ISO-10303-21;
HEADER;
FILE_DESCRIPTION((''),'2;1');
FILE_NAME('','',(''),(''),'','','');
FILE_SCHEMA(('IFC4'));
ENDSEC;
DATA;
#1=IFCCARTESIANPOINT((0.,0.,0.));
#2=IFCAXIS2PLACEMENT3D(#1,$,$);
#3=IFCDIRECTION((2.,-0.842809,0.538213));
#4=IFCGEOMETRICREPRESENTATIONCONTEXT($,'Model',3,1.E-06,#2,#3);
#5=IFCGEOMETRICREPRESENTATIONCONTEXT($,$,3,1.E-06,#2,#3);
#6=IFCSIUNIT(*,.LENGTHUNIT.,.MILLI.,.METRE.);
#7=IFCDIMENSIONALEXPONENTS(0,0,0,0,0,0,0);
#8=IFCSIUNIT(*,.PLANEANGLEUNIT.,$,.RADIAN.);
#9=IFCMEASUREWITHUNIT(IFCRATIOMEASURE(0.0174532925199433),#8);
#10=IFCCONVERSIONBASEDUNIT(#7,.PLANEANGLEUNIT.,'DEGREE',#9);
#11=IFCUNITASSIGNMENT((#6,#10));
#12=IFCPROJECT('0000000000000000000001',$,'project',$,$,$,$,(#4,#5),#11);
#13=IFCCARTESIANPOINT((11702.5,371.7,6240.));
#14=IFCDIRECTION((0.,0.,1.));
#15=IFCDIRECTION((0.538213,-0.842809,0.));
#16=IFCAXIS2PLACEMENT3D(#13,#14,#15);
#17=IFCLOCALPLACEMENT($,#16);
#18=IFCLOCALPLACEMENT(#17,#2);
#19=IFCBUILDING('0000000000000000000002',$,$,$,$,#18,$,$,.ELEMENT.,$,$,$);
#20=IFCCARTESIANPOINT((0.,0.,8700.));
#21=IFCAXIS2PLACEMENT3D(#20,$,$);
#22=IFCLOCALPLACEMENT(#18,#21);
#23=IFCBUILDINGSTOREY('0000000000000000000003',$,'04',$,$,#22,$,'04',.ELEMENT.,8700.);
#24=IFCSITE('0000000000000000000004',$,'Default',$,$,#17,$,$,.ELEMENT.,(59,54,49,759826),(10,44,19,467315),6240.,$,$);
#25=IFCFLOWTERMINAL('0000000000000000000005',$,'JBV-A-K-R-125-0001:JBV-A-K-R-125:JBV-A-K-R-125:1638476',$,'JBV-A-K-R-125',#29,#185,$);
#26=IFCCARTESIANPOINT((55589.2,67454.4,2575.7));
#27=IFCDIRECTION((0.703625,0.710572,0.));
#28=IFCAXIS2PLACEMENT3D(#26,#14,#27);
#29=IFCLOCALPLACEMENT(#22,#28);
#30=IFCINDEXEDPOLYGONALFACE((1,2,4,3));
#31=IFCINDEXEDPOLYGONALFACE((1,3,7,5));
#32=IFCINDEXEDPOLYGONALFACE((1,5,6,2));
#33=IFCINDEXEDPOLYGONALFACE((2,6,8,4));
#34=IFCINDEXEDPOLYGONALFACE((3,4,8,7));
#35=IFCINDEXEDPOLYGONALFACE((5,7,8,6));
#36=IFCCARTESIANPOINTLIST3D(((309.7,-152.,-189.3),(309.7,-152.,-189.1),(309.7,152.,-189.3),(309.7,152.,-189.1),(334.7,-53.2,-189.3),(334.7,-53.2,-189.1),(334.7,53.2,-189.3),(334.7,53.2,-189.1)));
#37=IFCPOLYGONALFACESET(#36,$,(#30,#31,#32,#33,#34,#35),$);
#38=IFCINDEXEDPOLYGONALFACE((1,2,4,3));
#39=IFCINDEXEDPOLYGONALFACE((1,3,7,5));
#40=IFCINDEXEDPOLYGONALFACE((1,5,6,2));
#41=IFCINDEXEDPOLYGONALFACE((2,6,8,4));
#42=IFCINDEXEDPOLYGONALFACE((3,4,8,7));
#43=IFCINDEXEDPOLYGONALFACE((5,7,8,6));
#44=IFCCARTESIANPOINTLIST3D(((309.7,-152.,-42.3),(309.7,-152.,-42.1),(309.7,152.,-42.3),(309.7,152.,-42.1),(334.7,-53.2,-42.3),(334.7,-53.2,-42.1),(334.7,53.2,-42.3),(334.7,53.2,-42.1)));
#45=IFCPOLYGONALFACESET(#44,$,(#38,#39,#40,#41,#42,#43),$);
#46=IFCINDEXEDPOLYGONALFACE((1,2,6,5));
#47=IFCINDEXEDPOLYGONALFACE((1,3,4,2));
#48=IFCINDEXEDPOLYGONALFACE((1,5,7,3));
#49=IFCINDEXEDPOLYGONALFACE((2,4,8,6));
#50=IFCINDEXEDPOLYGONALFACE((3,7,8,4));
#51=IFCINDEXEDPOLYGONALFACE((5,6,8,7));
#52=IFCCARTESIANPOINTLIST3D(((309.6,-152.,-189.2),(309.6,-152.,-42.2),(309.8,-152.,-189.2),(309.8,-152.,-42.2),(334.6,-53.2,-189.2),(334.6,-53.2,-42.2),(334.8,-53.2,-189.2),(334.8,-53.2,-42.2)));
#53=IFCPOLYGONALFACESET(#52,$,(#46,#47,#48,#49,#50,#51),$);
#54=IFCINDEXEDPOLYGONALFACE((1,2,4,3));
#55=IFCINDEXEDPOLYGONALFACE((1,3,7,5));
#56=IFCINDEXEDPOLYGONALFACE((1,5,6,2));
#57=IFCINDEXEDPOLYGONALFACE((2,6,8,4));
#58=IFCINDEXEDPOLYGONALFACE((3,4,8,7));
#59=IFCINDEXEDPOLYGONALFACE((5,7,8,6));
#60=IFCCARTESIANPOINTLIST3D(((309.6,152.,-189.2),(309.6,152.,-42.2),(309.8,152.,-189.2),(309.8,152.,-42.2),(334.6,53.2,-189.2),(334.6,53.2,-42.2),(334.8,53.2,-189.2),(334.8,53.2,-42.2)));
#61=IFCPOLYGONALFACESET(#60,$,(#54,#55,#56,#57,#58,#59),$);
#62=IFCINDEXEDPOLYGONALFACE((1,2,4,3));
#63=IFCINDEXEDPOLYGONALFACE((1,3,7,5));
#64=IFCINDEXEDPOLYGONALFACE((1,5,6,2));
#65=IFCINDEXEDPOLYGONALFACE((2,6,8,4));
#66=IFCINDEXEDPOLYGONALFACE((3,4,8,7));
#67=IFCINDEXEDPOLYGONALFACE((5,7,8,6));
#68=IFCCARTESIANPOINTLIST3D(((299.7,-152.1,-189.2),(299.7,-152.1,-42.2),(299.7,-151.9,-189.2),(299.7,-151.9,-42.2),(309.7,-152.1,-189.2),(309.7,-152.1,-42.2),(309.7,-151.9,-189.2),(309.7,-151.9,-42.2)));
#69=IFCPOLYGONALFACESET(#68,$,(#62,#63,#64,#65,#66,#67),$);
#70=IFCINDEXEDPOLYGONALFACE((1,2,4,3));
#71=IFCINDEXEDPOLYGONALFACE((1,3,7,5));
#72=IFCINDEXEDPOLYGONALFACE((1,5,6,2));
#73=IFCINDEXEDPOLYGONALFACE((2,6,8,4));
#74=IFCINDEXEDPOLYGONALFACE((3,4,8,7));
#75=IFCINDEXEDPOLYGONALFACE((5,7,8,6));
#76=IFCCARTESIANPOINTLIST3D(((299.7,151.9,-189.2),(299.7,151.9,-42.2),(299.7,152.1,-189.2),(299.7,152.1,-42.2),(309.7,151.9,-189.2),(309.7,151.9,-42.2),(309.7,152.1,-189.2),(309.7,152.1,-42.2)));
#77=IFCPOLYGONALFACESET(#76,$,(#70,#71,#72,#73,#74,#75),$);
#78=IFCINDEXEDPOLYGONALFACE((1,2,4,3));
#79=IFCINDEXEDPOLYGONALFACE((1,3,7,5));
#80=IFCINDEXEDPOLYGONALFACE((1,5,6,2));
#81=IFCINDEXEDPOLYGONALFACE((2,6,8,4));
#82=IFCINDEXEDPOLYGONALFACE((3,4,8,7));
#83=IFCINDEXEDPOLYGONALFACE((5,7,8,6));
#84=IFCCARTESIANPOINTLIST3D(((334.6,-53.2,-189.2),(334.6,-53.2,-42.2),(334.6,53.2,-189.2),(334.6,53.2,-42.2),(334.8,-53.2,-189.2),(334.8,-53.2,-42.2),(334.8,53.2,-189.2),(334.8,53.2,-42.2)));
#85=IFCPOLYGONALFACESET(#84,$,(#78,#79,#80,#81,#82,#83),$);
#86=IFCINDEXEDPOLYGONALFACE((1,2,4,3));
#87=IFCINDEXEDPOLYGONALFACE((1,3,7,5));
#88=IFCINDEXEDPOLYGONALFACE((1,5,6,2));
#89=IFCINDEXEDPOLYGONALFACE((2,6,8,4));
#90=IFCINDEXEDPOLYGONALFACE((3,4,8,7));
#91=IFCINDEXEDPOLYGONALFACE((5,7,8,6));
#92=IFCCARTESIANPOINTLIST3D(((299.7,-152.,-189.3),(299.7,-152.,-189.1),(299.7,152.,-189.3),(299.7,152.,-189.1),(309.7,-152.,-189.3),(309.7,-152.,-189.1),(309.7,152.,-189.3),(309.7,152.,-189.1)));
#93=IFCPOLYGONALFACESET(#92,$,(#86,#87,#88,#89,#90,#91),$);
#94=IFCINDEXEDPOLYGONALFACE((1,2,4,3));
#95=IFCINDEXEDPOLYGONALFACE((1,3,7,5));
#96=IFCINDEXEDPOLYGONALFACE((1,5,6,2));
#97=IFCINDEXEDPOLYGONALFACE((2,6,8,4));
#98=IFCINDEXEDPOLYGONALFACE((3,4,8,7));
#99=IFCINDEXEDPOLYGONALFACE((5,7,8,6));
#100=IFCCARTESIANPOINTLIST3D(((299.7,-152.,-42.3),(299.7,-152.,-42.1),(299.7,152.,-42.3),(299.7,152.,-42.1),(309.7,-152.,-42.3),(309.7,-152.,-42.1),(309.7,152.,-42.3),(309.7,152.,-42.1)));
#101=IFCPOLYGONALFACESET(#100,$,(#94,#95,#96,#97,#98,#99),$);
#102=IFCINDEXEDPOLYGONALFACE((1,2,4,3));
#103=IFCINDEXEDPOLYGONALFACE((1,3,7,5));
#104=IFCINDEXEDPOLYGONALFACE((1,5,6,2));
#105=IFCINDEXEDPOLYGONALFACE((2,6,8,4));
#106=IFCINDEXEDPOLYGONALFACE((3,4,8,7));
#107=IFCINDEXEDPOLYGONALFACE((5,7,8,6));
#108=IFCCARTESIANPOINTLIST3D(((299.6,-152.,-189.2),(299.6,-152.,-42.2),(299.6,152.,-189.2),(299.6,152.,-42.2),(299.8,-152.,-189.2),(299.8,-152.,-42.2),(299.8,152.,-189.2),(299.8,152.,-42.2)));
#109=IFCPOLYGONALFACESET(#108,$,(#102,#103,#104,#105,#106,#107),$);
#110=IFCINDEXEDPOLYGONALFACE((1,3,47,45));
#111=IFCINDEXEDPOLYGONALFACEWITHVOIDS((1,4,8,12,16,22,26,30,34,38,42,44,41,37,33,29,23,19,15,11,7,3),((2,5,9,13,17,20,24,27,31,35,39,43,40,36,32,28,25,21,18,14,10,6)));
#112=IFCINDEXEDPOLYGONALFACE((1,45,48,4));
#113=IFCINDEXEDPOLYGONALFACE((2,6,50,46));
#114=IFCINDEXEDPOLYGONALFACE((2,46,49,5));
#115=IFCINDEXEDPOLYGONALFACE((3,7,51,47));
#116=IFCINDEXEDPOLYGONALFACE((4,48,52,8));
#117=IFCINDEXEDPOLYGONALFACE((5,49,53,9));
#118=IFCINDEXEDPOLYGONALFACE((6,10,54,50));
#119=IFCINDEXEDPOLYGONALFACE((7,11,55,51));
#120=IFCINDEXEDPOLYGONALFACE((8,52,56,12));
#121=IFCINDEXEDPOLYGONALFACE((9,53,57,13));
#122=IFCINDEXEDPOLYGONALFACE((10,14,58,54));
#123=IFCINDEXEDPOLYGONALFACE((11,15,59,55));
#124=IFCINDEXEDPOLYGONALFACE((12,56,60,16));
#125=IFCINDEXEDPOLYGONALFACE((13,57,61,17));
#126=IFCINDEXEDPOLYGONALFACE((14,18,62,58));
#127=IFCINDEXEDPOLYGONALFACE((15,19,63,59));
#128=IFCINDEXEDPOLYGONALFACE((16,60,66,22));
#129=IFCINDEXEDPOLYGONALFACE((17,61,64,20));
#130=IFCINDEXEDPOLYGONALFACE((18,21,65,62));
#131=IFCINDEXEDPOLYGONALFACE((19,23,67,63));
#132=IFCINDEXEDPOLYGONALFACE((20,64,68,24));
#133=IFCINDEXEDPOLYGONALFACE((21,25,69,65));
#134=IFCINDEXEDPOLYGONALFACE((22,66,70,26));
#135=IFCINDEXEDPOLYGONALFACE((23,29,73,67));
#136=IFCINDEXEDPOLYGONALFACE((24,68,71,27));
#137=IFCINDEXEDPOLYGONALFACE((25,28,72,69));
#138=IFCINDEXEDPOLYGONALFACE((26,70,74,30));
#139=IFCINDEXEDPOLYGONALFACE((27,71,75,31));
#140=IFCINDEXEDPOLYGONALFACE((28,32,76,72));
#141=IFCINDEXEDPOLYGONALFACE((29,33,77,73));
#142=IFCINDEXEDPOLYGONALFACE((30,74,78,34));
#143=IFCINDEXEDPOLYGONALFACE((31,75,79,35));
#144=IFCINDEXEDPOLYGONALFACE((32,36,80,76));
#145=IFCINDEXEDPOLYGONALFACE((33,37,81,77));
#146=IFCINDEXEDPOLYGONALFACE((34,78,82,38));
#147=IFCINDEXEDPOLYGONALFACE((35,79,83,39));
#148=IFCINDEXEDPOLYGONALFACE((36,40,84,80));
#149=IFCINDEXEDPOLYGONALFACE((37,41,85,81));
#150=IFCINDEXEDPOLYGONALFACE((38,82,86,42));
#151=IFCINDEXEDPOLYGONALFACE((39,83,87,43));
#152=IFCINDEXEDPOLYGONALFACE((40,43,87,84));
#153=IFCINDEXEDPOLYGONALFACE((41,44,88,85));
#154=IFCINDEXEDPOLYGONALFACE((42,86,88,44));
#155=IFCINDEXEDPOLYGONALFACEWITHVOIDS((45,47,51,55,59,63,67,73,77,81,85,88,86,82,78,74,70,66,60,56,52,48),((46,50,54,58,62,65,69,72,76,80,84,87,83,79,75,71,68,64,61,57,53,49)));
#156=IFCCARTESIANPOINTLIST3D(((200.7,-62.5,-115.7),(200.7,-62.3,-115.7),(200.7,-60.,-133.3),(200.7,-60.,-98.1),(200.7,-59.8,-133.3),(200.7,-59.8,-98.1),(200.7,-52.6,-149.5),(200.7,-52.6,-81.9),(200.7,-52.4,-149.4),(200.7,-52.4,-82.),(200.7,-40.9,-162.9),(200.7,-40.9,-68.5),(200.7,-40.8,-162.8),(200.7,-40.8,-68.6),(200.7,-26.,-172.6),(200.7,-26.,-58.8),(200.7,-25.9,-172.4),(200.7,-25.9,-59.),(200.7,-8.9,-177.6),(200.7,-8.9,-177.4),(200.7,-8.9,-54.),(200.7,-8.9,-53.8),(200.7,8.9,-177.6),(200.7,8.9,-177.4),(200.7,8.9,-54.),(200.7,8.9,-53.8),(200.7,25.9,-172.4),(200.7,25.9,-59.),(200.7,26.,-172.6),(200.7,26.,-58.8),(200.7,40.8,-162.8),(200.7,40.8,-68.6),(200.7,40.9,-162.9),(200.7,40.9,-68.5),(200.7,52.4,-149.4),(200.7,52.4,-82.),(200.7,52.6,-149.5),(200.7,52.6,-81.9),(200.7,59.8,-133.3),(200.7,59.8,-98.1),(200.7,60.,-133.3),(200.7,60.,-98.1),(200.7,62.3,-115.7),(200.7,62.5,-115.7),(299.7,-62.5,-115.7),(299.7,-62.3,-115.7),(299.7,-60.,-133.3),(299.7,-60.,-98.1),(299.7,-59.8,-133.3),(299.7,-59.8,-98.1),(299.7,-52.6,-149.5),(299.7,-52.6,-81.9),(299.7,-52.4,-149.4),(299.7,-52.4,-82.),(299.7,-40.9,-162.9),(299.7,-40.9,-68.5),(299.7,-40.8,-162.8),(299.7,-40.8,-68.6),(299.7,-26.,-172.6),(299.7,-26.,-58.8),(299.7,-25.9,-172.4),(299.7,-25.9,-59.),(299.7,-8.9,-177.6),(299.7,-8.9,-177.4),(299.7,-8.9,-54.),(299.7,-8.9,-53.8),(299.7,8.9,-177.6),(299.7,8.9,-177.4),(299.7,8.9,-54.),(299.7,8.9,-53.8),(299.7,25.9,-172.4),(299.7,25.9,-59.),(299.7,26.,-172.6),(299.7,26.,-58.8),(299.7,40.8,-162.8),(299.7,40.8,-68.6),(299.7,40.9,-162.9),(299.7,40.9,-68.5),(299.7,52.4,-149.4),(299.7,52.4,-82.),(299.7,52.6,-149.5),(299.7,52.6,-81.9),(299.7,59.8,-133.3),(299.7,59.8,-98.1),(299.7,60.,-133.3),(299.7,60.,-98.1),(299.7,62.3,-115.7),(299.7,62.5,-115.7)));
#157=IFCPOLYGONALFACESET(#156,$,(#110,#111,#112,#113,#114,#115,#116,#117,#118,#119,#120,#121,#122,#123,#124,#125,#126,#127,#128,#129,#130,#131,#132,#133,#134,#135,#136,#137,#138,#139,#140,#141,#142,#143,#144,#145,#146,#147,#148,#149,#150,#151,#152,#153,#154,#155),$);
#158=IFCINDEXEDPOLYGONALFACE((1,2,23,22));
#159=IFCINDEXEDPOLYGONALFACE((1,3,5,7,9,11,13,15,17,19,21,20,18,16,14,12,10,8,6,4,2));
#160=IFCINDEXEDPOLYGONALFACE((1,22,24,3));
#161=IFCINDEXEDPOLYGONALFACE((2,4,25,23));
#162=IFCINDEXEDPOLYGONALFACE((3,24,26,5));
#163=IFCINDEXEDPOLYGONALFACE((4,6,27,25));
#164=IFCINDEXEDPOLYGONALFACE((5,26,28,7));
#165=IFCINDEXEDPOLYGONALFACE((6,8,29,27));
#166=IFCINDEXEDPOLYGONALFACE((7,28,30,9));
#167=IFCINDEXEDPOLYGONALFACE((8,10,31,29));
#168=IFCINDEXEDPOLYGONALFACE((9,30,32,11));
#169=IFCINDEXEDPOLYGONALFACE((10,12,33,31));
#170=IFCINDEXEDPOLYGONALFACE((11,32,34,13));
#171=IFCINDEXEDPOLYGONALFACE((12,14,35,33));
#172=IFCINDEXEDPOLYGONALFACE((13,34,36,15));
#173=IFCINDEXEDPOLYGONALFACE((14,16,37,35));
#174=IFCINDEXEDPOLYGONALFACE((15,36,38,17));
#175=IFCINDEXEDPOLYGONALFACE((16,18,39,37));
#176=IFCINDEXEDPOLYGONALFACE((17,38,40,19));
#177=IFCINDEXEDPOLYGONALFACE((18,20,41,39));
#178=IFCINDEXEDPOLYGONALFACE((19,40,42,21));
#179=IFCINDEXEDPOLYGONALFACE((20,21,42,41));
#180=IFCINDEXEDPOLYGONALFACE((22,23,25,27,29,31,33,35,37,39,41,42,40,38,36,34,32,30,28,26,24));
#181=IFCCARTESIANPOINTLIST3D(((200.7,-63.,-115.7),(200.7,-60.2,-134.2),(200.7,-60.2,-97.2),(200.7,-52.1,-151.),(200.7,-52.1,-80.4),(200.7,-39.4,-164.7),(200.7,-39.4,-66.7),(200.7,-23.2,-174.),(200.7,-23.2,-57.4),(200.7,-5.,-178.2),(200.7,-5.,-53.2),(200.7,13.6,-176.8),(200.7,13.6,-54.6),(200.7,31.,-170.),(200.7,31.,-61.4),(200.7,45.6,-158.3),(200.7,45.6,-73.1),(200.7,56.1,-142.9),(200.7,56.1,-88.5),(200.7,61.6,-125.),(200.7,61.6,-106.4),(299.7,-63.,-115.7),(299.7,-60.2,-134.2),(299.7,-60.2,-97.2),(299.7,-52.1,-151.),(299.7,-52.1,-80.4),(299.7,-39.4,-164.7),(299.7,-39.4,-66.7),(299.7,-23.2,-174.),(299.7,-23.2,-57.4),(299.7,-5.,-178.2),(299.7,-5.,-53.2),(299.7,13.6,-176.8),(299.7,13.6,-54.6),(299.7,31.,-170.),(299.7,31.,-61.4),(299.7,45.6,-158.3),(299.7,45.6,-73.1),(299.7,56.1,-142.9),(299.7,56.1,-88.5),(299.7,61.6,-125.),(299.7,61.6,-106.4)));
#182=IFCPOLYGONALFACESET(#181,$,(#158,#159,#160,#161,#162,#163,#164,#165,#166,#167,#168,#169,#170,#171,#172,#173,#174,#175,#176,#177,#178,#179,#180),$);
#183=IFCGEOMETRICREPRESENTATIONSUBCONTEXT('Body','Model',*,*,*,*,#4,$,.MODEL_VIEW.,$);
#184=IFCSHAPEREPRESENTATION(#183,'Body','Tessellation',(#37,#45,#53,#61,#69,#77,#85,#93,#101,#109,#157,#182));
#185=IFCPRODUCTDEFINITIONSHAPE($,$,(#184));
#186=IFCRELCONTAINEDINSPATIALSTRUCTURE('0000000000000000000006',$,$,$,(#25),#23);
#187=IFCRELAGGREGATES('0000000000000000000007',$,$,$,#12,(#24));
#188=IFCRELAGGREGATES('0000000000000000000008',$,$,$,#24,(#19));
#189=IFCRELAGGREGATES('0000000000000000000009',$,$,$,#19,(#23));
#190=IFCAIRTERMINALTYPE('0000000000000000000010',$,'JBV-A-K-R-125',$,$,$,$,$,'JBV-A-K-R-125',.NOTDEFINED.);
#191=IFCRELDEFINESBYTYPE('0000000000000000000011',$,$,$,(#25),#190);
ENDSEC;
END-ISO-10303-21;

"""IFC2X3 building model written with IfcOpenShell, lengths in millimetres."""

from ifc_helpers import new_model, entity, si_unit, converted_unit, direction, frame, frame_2d, origin, origin_2d_with_axis, place, context, subcontext, project, spatial, polyline, circle_curve, parameter, trimmed, segment, composite_curve, rectangle, circle, outline, extrude, source, transform, mapped, type_object, type_shapes, element, save


model = new_model("IFC2X3")

# Units and contexts
model_context = context("Model", 3, precision=1e-06, world=origin(), true_north=direction((2.0, -0.842809, 0.538213)))
context_of_model = context(None, 3, precision=1e-06, world=origin(), true_north=direction((2.0, -0.842809, 0.538213)))
body_context = subcontext(model_context, "Body", "Model", "MODEL_VIEW")
ifc_project = project(units=[si_unit("LENGTHUNIT", "METRE", prefix="MILLI"), converted_unit("PLANEANGLEUNIT", "DEGREE", entity("IfcRatioMeasure", 0.0174532925199433), si_unit("PLANEANGLEUNIT", "RADIAN"), dimensions=[0, 0, 0, 0, 0, 0, 0])], contexts=[model_context, context_of_model])

# Site, building, storey
site_placement = place(None, frame((11702.5, 371.7, 6240.0), z_axis=(0.0, 0.0, 1.0), x_axis=(0.538213, -0.842809, 0.0)))
site = spatial("IfcSite", under=ifc_project, at=site_placement, Name="Default", CompositionType="ELEMENT", RefLatitude=(59, 54, 49, 759826), RefLongitude=(10, 44, 19, 467315), RefElevation=6240.0)
building_placement = place(site_placement, origin())
building = spatial("IfcBuilding", under=site, at=building_placement, CompositionType="ELEMENT")
storey_placement = place(building_placement, frame((0.0, 0.0, 8700.0)))
storey = spatial("IfcBuildingStorey", under=building, at=storey_placement, Name="04", LongName="04", CompositionType="ELEMENT", Elevation=8700.0)

# Flow terminal
air_terminal_type_1 = type_object("IfcAirTerminalType", Name="JBV-A-K-R-125", ElementType="JBV-A-K-R-125", PredefinedType="NOTDEFINED")
shared_shape_1 = source(origin(), body_context, "Body", "SweptSolid", [
    extrude(outline(polyline([(-150.4, -25.2), (-48.5, -25.2), (54.6, 0.9), (144.3, 49.4), (-150.4, -25.2)])), frame((322.2, 0.0, -189.3), z_axis=(0.0, 0.0, 1.0), x_axis=(0.245305, 0.969446, 0.0)), (0.0, 0.0, 1.0), 0.2),
    extrude(outline(polyline([(-150.4, -25.2), (-48.5, -25.2), (54.6, 0.9), (144.3, 49.4), (-150.4, -25.2)])), frame((322.2, 0.0, -42.3), z_axis=(0.0, 0.0, 1.0), x_axis=(0.245305, 0.969446, 0.0)), (0.0, 0.0, 1.0), 0.2),
    extrude(rectangle(XDim=101.9, YDim=0.2, at=frame_2d((0.0, 0.0), x_axis=(1.0, 0.0))), frame((322.2, -102.6, -189.2), z_axis=(0.0, 0.0, 1.0), x_axis=(-0.245305, -0.969446, 0.0)), (0.0, 0.0, 1.0), 147.0),
    extrude(rectangle(XDim=101.9, YDim=0.2, at=frame_2d((0.0, 0.0), x_axis=(1.0, 0.0))), frame((322.2, 102.6, -189.2), z_axis=(0.0, 0.0, 1.0), x_axis=(-0.245305, 0.969446, 0.0)), (0.0, 0.0, 1.0), 147.0),
    extrude(rectangle(XDim=10.0, YDim=0.2, at=frame_2d((0.0, 0.0), x_axis=(1.0, 0.0))), frame((304.7, -152.0, -189.2), z_axis=(0.0, 0.0, 1.0), x_axis=(-1.0, 0.0, 0.0)), (0.0, 0.0, 1.0), 147.0),
    extrude(rectangle(XDim=10.0, YDim=0.2, at=frame_2d((0.0, 0.0), x_axis=(1.0, 0.0))), frame((304.7, 152.0, -189.2), z_axis=(0.0, 0.0, 1.0), x_axis=(-1.0, 0.0, 0.0)), (0.0, 0.0, 1.0), 147.0),
    extrude(rectangle(XDim=106.4, YDim=0.2, at=frame_2d((0.0, 0.0), x_axis=(1.0, 0.0))), frame((334.7, 0.0, -189.2), z_axis=(0.0, 0.0, 1.0), x_axis=(0.0, -1.0, 0.0)), (0.0, 0.0, 1.0), 147.0),
    extrude(rectangle(XDim=10.0, YDim=304.0, at=frame_2d((0.0, 0.0), x_axis=(1.0, 0.0))), frame((304.7, 0.0, -189.3)), (0.0, 0.0, 1.0), 0.2),
    extrude(rectangle(XDim=10.0, YDim=304.0, at=frame_2d((0.0, 0.0), x_axis=(1.0, 0.0))), frame((304.7, 0.0, -42.3)), (0.0, 0.0, 1.0), 0.2),
    extrude(rectangle(XDim=304.0, YDim=0.2, at=frame_2d((0.0, 0.0), x_axis=(1.0, 0.0))), frame((299.7, 0.0, -189.2), z_axis=(0.0, 0.0, 1.0), x_axis=(0.0, -1.0, 0.0)), (0.0, 0.0, 1.0), 147.0),
    extrude(outline(composite_curve([segment(trimmed(circle_curve(origin_2d_with_axis(), 62.5), [parameter(0.0)], [parameter(180.0)], True, "PARAMETER"), True, "CONTINUOUS"), segment(trimmed(circle_curve(origin_2d_with_axis(), 62.5), [parameter(180.0)], [parameter(0.0)], True, "PARAMETER"), True, "CONTINUOUS")], self_intersect=False), holes=[composite_curve([segment(trimmed(circle_curve(origin_2d_with_axis(), 62.3), [parameter(180.0)], [parameter(360.0)], True, "PARAMETER"), False, "CONTINUOUS"), segment(trimmed(circle_curve(origin_2d_with_axis(), 62.3), [parameter(0.0)], [parameter(180.0)], True, "PARAMETER"), False, "CONTINUOUS")], self_intersect=False)]), frame((200.7, 0.0, -115.7), z_axis=(1.0, 0.0, 0.0), x_axis=(0.0, -1.0, 0.0)), (0.0, 0.0, 1.0), 99.0),
    extrude(circle(Radius=62.6, at=frame_2d((0.0, 0.0), x_axis=(1.0, 0.0))), frame((200.7, -0.3, -115.7), z_axis=(1.0, 0.0, 0.0), x_axis=(0.0, -1.0, 0.0)), (0.0, 0.0, 1.0), 99.0),
])
type_shapes(air_terminal_type_1, [shared_shape_1])
for number, where, z_axis, x_axis, name in (
    (1, (55589.2, 67454.4, 2575.7), (0.0, 0.0, 1.0), (0.703625, 0.710572, 0.0), "JBV-A-K-R-125-0001:JBV-A-K-R-125:JBV-A-K-R-125:1638476"),
):
    element("IfcFlowTerminal", number, at=place(storey_placement, frame(where, z_axis=z_axis, x_axis=x_axis)), inside=storey, type_object=air_terminal_type_1, Name=name, ObjectType="JBV-A-K-R-125", context=body_context, shape_type="MappedRepresentation", body=[
        mapped(shared_shape_1, transform((0.0, 0.0, 0.0), scale=1.0)),
    ])

save(model, "model.ifc")
